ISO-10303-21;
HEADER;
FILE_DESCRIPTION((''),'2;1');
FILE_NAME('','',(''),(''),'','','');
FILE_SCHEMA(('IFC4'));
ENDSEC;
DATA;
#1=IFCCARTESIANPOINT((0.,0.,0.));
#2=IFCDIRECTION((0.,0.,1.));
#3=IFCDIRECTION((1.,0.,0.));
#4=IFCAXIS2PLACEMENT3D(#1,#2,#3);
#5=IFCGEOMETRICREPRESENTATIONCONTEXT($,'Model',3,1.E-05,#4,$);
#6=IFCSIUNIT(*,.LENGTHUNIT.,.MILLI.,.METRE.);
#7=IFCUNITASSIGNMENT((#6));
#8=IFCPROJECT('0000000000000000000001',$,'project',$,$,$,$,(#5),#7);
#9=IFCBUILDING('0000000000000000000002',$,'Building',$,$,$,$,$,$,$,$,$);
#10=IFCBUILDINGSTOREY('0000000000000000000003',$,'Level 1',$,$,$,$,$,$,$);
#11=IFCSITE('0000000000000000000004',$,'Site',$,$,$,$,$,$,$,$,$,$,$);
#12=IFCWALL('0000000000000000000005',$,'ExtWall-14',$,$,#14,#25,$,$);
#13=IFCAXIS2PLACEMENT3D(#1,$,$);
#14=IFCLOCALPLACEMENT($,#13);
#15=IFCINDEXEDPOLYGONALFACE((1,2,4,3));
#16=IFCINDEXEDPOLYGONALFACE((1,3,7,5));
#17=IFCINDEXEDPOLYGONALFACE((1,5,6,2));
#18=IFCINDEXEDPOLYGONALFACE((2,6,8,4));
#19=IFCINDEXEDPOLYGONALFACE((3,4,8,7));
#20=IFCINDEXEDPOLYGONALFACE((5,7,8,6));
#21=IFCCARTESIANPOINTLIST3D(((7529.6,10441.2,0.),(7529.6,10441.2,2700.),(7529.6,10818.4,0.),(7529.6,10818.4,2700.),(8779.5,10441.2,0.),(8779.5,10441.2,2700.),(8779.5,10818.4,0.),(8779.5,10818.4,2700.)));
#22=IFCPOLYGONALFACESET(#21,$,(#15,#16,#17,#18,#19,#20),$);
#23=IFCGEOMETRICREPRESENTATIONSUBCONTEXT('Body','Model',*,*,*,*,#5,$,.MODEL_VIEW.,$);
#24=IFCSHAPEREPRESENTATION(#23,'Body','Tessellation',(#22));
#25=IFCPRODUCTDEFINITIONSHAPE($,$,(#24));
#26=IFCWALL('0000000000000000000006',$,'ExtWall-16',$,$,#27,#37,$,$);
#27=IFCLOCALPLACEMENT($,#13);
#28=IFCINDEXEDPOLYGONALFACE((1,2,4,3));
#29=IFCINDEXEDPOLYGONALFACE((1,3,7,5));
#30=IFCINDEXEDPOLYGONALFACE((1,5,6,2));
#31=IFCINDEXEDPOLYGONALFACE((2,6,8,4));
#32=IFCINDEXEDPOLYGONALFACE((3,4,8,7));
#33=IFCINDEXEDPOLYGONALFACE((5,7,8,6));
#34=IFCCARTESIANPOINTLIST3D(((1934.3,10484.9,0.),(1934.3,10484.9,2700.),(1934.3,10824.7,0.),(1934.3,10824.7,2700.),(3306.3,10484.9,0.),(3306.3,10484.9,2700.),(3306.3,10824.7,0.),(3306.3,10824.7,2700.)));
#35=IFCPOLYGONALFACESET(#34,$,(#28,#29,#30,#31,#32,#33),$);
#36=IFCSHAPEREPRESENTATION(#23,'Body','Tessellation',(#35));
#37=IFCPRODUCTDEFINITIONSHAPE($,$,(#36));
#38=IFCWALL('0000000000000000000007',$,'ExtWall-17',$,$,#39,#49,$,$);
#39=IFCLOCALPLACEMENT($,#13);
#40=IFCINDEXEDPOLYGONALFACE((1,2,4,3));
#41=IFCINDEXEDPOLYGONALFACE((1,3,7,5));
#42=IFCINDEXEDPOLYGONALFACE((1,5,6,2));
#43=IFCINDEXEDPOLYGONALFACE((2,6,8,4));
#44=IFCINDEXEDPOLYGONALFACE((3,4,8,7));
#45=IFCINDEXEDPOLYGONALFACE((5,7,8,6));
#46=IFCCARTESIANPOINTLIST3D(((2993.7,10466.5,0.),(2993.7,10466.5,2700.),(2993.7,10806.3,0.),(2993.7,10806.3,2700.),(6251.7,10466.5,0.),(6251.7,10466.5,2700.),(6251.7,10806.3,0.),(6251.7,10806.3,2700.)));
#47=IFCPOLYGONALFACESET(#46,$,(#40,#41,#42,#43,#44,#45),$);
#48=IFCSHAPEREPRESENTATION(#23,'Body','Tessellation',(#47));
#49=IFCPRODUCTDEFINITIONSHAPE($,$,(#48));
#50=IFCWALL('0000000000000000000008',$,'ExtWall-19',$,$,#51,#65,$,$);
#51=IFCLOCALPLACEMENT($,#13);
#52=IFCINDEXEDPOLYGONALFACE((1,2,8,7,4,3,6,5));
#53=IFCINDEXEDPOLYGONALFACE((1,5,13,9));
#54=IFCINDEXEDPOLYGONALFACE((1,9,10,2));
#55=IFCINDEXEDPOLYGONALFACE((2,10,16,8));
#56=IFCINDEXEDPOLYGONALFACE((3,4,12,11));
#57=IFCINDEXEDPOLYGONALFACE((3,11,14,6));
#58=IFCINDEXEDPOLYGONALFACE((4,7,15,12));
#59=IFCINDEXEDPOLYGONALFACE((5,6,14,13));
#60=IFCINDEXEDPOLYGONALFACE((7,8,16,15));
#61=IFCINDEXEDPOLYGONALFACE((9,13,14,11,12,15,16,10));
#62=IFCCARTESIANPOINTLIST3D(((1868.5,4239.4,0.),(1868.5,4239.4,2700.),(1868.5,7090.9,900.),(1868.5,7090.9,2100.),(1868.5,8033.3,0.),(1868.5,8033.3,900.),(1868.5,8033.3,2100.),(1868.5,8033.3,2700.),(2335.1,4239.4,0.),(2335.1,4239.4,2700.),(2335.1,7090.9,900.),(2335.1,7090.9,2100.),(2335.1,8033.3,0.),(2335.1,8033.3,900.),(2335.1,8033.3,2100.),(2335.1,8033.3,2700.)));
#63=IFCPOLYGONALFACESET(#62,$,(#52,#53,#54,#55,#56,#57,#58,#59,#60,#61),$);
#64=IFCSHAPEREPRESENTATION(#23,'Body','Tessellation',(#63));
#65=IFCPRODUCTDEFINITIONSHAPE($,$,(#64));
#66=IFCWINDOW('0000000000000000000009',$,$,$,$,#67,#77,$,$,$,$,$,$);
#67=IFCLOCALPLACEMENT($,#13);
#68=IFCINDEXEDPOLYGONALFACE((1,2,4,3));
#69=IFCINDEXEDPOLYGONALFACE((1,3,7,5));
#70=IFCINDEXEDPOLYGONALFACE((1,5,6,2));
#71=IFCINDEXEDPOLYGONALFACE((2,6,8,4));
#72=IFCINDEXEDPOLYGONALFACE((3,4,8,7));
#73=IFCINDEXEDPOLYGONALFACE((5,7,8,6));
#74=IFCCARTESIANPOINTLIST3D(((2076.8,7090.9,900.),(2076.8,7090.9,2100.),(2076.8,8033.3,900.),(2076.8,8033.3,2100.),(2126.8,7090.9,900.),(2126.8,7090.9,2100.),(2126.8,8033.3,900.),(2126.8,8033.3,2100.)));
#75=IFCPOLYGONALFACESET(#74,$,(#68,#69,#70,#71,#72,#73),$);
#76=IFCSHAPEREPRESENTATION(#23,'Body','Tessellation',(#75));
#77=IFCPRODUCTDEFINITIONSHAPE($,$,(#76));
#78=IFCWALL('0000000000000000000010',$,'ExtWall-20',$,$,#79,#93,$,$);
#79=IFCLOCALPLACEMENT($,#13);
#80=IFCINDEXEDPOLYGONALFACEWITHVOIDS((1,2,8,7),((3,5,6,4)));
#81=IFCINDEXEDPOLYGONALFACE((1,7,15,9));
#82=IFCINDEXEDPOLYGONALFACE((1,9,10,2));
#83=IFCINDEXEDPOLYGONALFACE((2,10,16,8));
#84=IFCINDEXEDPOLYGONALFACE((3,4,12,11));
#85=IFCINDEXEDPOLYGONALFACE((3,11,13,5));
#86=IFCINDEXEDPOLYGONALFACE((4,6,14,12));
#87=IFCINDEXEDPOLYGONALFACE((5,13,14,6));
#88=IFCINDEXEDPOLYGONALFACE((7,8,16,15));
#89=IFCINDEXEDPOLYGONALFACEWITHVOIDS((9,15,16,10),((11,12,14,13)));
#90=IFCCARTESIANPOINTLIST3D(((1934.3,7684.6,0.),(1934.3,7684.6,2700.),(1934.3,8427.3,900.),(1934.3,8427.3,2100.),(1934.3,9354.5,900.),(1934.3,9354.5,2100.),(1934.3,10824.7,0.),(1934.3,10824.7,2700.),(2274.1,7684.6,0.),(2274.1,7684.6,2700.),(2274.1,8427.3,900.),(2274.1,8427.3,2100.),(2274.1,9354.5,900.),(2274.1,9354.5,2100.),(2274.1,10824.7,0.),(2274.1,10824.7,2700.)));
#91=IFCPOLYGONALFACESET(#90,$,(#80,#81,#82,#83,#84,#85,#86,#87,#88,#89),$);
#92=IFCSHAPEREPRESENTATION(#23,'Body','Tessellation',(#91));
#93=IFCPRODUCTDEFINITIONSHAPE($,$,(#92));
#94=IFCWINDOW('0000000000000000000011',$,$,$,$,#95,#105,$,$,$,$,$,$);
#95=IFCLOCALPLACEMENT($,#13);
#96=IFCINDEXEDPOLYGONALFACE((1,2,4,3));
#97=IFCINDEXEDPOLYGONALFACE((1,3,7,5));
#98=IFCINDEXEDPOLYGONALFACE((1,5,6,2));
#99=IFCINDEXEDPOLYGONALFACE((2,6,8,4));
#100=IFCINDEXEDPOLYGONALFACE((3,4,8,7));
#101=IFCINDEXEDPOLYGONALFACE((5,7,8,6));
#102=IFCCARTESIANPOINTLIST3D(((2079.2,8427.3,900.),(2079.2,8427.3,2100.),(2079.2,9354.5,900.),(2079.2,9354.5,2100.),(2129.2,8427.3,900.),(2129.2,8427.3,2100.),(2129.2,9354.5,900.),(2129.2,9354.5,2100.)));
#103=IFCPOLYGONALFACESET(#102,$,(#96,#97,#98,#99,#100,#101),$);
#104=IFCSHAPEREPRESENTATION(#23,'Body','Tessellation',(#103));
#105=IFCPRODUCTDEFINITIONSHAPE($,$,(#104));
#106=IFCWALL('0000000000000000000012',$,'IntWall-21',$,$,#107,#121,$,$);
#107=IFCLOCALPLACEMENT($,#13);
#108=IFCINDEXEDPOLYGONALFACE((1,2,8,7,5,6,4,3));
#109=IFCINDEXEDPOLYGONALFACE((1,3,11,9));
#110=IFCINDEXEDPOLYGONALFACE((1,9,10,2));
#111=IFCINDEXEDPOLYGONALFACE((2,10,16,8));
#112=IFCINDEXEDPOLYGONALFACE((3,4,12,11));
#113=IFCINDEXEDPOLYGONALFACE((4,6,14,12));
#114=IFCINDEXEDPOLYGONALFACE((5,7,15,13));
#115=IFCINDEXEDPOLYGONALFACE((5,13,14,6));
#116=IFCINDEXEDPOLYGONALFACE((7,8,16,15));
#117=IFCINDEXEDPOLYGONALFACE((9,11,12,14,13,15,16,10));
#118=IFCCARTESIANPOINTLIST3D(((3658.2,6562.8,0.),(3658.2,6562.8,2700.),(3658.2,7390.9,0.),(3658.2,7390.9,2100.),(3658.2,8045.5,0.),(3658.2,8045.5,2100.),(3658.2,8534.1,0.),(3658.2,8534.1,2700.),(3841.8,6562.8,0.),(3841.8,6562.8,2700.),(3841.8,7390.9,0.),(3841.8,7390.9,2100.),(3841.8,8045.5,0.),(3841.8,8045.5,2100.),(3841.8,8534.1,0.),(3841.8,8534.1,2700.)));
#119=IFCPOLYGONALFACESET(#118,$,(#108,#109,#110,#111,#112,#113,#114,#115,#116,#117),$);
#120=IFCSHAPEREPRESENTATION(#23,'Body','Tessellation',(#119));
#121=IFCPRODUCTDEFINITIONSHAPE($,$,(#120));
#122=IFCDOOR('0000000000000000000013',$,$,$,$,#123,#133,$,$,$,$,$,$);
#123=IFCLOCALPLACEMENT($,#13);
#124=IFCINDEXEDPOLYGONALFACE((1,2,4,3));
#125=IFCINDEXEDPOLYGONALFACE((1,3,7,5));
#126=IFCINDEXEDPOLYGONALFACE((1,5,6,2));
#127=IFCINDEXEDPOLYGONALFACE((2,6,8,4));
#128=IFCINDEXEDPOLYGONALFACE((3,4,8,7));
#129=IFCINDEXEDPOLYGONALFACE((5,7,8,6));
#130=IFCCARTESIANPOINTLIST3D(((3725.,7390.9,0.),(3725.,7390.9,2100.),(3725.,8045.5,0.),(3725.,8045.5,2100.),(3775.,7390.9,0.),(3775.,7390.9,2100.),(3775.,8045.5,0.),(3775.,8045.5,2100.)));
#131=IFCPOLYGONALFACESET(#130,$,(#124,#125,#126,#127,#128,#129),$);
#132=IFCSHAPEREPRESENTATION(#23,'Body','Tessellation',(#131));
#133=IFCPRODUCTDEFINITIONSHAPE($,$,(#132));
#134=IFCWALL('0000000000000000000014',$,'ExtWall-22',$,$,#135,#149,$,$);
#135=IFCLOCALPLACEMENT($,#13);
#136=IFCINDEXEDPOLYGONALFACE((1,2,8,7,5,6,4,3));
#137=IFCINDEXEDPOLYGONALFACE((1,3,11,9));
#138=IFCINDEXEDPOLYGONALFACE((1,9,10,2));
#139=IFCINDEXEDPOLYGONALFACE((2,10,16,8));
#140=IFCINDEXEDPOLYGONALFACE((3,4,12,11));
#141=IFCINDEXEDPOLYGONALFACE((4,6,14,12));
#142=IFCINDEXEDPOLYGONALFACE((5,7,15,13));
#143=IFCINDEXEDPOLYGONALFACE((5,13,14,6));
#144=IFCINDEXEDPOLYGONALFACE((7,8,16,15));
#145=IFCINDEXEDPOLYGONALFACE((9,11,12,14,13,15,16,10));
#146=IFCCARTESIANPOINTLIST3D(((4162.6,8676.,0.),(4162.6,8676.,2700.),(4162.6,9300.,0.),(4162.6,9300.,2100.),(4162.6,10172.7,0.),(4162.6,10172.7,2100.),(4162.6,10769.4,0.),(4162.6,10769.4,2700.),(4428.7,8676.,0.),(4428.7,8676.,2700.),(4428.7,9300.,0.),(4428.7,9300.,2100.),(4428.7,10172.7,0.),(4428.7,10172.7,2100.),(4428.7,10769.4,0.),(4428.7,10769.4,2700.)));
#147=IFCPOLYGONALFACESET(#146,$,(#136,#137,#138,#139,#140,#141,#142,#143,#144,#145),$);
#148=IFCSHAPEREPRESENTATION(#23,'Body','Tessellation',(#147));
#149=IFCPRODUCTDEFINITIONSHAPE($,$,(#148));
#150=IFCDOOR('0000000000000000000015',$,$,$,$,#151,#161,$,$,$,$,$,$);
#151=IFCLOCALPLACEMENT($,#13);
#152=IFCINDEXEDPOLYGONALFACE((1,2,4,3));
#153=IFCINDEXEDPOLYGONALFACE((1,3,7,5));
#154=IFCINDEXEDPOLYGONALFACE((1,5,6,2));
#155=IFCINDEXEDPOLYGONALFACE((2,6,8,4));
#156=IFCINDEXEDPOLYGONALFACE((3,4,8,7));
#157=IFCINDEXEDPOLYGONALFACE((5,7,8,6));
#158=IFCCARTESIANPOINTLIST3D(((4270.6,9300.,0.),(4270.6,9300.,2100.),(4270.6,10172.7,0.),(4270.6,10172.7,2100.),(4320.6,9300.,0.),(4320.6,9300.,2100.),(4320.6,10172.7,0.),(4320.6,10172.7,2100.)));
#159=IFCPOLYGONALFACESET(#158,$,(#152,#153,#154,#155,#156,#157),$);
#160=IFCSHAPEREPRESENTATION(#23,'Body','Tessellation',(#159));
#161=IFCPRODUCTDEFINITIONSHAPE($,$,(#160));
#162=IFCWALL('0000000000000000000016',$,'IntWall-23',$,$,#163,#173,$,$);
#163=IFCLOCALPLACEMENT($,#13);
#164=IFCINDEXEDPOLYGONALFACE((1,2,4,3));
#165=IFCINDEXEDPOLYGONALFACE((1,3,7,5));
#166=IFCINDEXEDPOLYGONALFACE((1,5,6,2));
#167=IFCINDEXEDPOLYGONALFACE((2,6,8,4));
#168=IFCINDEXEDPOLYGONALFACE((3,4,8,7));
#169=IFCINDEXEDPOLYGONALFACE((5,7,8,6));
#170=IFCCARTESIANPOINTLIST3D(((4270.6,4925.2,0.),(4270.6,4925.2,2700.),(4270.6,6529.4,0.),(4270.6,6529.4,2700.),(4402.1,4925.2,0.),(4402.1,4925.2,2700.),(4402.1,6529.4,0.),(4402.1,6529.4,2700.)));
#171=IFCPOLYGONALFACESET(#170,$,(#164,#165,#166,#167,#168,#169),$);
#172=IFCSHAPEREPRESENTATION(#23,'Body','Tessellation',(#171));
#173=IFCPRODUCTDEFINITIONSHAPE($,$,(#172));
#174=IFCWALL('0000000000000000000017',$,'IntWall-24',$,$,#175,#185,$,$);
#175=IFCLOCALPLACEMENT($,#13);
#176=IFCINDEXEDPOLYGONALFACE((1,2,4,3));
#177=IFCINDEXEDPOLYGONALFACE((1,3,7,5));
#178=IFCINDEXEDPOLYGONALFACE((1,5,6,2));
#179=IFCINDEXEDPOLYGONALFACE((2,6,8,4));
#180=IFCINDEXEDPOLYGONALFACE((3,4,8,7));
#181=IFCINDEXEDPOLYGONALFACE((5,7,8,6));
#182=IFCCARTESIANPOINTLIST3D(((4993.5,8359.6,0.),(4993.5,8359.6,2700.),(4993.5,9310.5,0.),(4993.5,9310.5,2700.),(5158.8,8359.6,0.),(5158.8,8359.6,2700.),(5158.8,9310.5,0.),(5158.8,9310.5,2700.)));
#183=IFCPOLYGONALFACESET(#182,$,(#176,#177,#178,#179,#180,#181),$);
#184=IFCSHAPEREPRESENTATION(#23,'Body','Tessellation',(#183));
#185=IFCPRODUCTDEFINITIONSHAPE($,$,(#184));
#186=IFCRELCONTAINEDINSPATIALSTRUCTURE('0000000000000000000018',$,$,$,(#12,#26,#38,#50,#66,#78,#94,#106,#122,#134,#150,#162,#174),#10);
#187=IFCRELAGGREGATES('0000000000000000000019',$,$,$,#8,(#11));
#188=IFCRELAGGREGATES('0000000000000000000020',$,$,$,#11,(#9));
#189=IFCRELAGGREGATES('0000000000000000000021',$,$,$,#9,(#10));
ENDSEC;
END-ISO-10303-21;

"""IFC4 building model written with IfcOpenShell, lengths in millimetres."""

from ifc_helpers import new_model, si_unit, frame, origin_with_axes, place, context, subcontext, project, spatial, indexed_curve, outline, extrude, element, fill, save


model = new_model("IFC4")

# Units and contexts
model_context = context("Model", 3, precision=1e-05, world=origin_with_axes())
body_context = subcontext(model_context, "Body", "Model", "MODEL_VIEW")
ifc_project = project(units=[si_unit("LENGTHUNIT", "METRE", prefix="MILLI")], contexts=[model_context])

# Site, building, storey
site = spatial("IfcSite", under=ifc_project, Name="Site")
building = spatial("IfcBuilding", under=site, Name="Building")
storey = spatial("IfcBuildingStorey", under=building, Name="Level 1")

# Walls
wall_1_placement = place(None, frame((7529.6, 10629.8, 0.0), z_axis=(0.0, 0.0, 1.0), x_axis=(1.0, 0.0, 0.0)))
element("IfcWall", 1, at=wall_1_placement, inside=storey, Name="ExtWall-14", context=body_context, shape_type="SweptSolid", body=[
    extrude(outline(indexed_curve([(0.0, 0.0), (0.0, 377.2), (1249.9, 377.2), (1249.9, 0.0), (0.0, 0.0)], self_intersect=False)), frame((0.0, -188.6, 0.0), z_axis=(0.0, 0.0, 1.0), x_axis=(1.0, 0.0, 0.0)), (0.0, 0.0, 1.0), 2700.0),
])
wall_2_placement = place(None, frame((1934.3, 10654.8, 0.0), z_axis=(0.0, 0.0, 1.0), x_axis=(1.0, 0.0, 0.0)))
element("IfcWall", 2, at=wall_2_placement, inside=storey, Name="ExtWall-16", context=body_context, shape_type="SweptSolid", body=[
    extrude(outline(indexed_curve([(0.0, 0.0), (0.0, 339.8), (1372.0, 339.8), (1372.0, 0.0), (0.0, 0.0)], self_intersect=False)), frame((0.0, -169.9, 0.0), z_axis=(0.0, 0.0, 1.0), x_axis=(1.0, 0.0, 0.0)), (0.0, 0.0, 1.0), 2700.0),
])
wall_3_placement = place(None, frame((2993.7, 10636.4, 0.0), z_axis=(0.0, 0.0, 1.0), x_axis=(1.0, 0.0, 0.0)))
element("IfcWall", 3, at=wall_3_placement, inside=storey, Name="ExtWall-17", context=body_context, shape_type="SweptSolid", body=[
    extrude(outline(indexed_curve([(0.0, 0.0), (0.0, 339.8), (3258.0, 339.8), (3258.0, 0.0), (0.0, 0.0)], self_intersect=False)), frame((0.0, -169.9, 0.0), z_axis=(0.0, 0.0, 1.0), x_axis=(1.0, 0.0, 0.0)), (0.0, 0.0, 1.0), 2700.0),
])

# Walls, openings, windows
wall_4_placement = place(None, frame((2101.8, 4239.4, 0.0), z_axis=(0.0, 0.0, 1.0), x_axis=(0.0, 1.0, 0.0)))
wall_4 = element("IfcWall", 4, at=wall_4_placement, inside=storey, Name="ExtWall-19", context=body_context, shape_type="SweptSolid", body=[
    extrude(outline(indexed_curve([(0.0, 0.0), (0.0, 466.6), (3793.9, 466.6), (3793.9, 0.0), (0.0, 0.0)], self_intersect=False)), frame((0.0, -233.3, 0.0), z_axis=(0.0, 0.0, 1.0), x_axis=(1.0, 0.0, 0.0)), (0.0, 0.0, 1.0), 2700.0),
])
opening_1_placement = place(wall_4_placement, frame((2851.5, 0.0, 900.0), z_axis=(0.0, 0.0, 1.0), x_axis=(1.0, 0.0, 0.0)))
opening_1 = element("IfcOpeningElement", 5, at=opening_1_placement, cuts=wall_4, context=body_context, shape_type="SweptSolid", body=[
    extrude(outline(indexed_curve([(0.0, 0.0), (0.0, 566.6), (942.4, 566.6), (942.4, 0.0), (0.0, 0.0)], self_intersect=False)), frame((0.0, -283.3, 0.0), z_axis=(0.0, 0.0, 1.0), x_axis=(1.0, 0.0, 0.0)), (0.0, 0.0, 1.0), 1200.0),
])
window_1_placement = place(opening_1_placement, origin_with_axes())
window_1 = element("IfcWindow", 6, at=window_1_placement, inside=storey, context=body_context, shape_type="SweptSolid", body=[
    extrude(outline(indexed_curve([(0.0, 0.0), (0.0, 50.0), (942.4, 50.0), (942.4, 0.0), (0.0, 0.0)], self_intersect=False)), frame((0.0, -25.0, 0.0), z_axis=(0.0, 0.0, 1.0), x_axis=(1.0, 0.0, 0.0)), (0.0, 0.0, 1.0), 1200.0),
])
fill(opening_1, window_1)
wall_5_placement = place(None, frame((2104.2, 7684.6, 0.0), z_axis=(0.0, 0.0, 1.0), x_axis=(0.0, 1.0, 0.0)))
wall_5 = element("IfcWall", 7, at=wall_5_placement, inside=storey, Name="ExtWall-20", context=body_context, shape_type="SweptSolid", body=[
    extrude(outline(indexed_curve([(0.0, 0.0), (0.0, 339.8), (3140.1, 339.8), (3140.1, 0.0), (0.0, 0.0)], self_intersect=False)), frame((0.0, -169.9, 0.0), z_axis=(0.0, 0.0, 1.0), x_axis=(1.0, 0.0, 0.0)), (0.0, 0.0, 1.0), 2700.0),
])
opening_2_placement = place(wall_5_placement, frame((742.6, 0.0, 900.0), z_axis=(0.0, 0.0, 1.0), x_axis=(1.0, 0.0, 0.0)))
opening_2 = element("IfcOpeningElement", 8, at=opening_2_placement, cuts=wall_5, context=body_context, shape_type="SweptSolid", body=[
    extrude(outline(indexed_curve([(0.0, 0.0), (0.0, 439.8), (927.3, 439.8), (927.3, 0.0), (0.0, 0.0)], self_intersect=False)), frame((0.0, -219.9, 0.0), z_axis=(0.0, 0.0, 1.0), x_axis=(1.0, 0.0, 0.0)), (0.0, 0.0, 1.0), 1200.0),
])
window_2_placement = place(opening_2_placement, origin_with_axes())
window_2 = element("IfcWindow", 9, at=window_2_placement, inside=storey, context=body_context, shape_type="SweptSolid", body=[
    extrude(outline(indexed_curve([(0.0, 0.0), (0.0, 50.0), (927.3, 50.0), (927.3, 0.0), (0.0, 0.0)], self_intersect=False)), frame((0.0, -25.0, 0.0), z_axis=(0.0, 0.0, 1.0), x_axis=(1.0, 0.0, 0.0)), (0.0, 0.0, 1.0), 1200.0),
])
fill(opening_2, window_2)

# Walls, openings, doors
wall_6_placement = place(None, frame((3750.0, 6562.8, 0.0), z_axis=(0.0, 0.0, 1.0), x_axis=(0.0, 1.0, 0.0)))
wall_6 = element("IfcWall", 10, at=wall_6_placement, inside=storey, Name="IntWall-21", context=body_context, shape_type="SweptSolid", body=[
    extrude(outline(indexed_curve([(0.0, 0.0), (0.0, 183.5), (1971.3, 183.5), (1971.3, 0.0), (0.0, 0.0)], self_intersect=False)), frame((0.0, -91.8, 0.0), z_axis=(0.0, 0.0, 1.0), x_axis=(1.0, 0.0, 0.0)), (0.0, 0.0, 1.0), 2700.0),
])
opening_3_placement = place(wall_6_placement, frame((828.1, 0.0, 0.0), z_axis=(0.0, 0.0, 1.0), x_axis=(1.0, 0.0, 0.0)))
opening_3 = element("IfcOpeningElement", 11, at=opening_3_placement, cuts=wall_6, context=body_context, shape_type="SweptSolid", body=[
    extrude(outline(indexed_curve([(0.0, 0.0), (0.0, 283.5), (654.5, 283.5), (654.5, 0.0), (0.0, 0.0)], self_intersect=False)), frame((0.0, -141.8, 0.0), z_axis=(0.0, 0.0, 1.0), x_axis=(1.0, 0.0, 0.0)), (0.0, 0.0, 1.0), 2100.0),
])
door_1_placement = place(opening_3_placement, origin_with_axes())
door_1 = element("IfcDoor", 12, at=door_1_placement, inside=storey, context=body_context, shape_type="SweptSolid", body=[
    extrude(outline(indexed_curve([(0.0, 0.0), (0.0, 50.0), (654.5, 50.0), (654.5, 0.0), (0.0, 0.0)], self_intersect=False)), frame((0.0, -25.0, 0.0), z_axis=(0.0, 0.0, 1.0), x_axis=(1.0, 0.0, 0.0)), (0.0, 0.0, 1.0), 2100.0),
])
fill(opening_3, door_1)
wall_7_placement = place(None, frame((4295.6, 8676.0, 0.0), z_axis=(0.0, 0.0, 1.0), x_axis=(0.0, 1.0, 0.0)))
wall_7 = element("IfcWall", 13, at=wall_7_placement, inside=storey, Name="ExtWall-22", context=body_context, shape_type="SweptSolid", body=[
    extrude(outline(indexed_curve([(0.0, 0.0), (0.0, 266.1), (2093.4, 266.1), (2093.4, 0.0), (0.0, 0.0)], self_intersect=False)), frame((0.0, -133.0, 0.0), z_axis=(0.0, 0.0, 1.0), x_axis=(1.0, 0.0, 0.0)), (0.0, 0.0, 1.0), 2700.0),
])
opening_4_placement = place(wall_7_placement, frame((624.0, 0.0, 0.0), z_axis=(0.0, 0.0, 1.0), x_axis=(1.0, 0.0, 0.0)))
opening_4 = element("IfcOpeningElement", 14, at=opening_4_placement, cuts=wall_7, context=body_context, shape_type="SweptSolid", body=[
    extrude(outline(indexed_curve([(0.0, 0.0), (0.0, 366.1), (872.7, 366.1), (872.7, 0.0), (0.0, 0.0)], self_intersect=False)), frame((0.0, -183.0, 0.0), z_axis=(0.0, 0.0, 1.0), x_axis=(1.0, 0.0, 0.0)), (0.0, 0.0, 1.0), 2100.0),
])
door_2_placement = place(opening_4_placement, origin_with_axes())
door_2 = element("IfcDoor", 15, at=door_2_placement, inside=storey, context=body_context, shape_type="SweptSolid", body=[
    extrude(outline(indexed_curve([(0.0, 0.0), (0.0, 50.0), (872.7, 50.0), (872.7, 0.0), (0.0, 0.0)], self_intersect=False)), frame((0.0, -25.0, 0.0), z_axis=(0.0, 0.0, 1.0), x_axis=(1.0, 0.0, 0.0)), (0.0, 0.0, 1.0), 2100.0),
])
fill(opening_4, door_2)

# Walls
wall_8_placement = place(None, frame((4336.4, 4925.2, 0.0), z_axis=(0.0, 0.0, 1.0), x_axis=(0.0, 1.0, 0.0)))
element("IfcWall", 16, at=wall_8_placement, inside=storey, Name="IntWall-23", context=body_context, shape_type="SweptSolid", body=[
    extrude(outline(indexed_curve([(0.0, 0.0), (0.0, 131.5), (1604.2, 131.5), (1604.2, 0.0), (0.0, 0.0)], self_intersect=False)), frame((0.0, -65.7, 0.0), z_axis=(0.0, 0.0, 1.0), x_axis=(1.0, 0.0, 0.0)), (0.0, 0.0, 1.0), 2700.0),
])
wall_9_placement = place(None, frame((5076.1, 8359.6, 0.0), z_axis=(0.0, 0.0, 1.0), x_axis=(0.0, 1.0, 0.0)))
element("IfcWall", 17, at=wall_9_placement, inside=storey, Name="IntWall-24", context=body_context, shape_type="SweptSolid", body=[
    extrude(outline(indexed_curve([(0.0, 0.0), (0.0, 165.4), (950.9, 165.4), (950.9, 0.0), (0.0, 0.0)], self_intersect=False)), frame((0.0, -82.7, 0.0), z_axis=(0.0, 0.0, 1.0), x_axis=(1.0, 0.0, 0.0)), (0.0, 0.0, 1.0), 2700.0),
])

save(model, "model.ifc")
